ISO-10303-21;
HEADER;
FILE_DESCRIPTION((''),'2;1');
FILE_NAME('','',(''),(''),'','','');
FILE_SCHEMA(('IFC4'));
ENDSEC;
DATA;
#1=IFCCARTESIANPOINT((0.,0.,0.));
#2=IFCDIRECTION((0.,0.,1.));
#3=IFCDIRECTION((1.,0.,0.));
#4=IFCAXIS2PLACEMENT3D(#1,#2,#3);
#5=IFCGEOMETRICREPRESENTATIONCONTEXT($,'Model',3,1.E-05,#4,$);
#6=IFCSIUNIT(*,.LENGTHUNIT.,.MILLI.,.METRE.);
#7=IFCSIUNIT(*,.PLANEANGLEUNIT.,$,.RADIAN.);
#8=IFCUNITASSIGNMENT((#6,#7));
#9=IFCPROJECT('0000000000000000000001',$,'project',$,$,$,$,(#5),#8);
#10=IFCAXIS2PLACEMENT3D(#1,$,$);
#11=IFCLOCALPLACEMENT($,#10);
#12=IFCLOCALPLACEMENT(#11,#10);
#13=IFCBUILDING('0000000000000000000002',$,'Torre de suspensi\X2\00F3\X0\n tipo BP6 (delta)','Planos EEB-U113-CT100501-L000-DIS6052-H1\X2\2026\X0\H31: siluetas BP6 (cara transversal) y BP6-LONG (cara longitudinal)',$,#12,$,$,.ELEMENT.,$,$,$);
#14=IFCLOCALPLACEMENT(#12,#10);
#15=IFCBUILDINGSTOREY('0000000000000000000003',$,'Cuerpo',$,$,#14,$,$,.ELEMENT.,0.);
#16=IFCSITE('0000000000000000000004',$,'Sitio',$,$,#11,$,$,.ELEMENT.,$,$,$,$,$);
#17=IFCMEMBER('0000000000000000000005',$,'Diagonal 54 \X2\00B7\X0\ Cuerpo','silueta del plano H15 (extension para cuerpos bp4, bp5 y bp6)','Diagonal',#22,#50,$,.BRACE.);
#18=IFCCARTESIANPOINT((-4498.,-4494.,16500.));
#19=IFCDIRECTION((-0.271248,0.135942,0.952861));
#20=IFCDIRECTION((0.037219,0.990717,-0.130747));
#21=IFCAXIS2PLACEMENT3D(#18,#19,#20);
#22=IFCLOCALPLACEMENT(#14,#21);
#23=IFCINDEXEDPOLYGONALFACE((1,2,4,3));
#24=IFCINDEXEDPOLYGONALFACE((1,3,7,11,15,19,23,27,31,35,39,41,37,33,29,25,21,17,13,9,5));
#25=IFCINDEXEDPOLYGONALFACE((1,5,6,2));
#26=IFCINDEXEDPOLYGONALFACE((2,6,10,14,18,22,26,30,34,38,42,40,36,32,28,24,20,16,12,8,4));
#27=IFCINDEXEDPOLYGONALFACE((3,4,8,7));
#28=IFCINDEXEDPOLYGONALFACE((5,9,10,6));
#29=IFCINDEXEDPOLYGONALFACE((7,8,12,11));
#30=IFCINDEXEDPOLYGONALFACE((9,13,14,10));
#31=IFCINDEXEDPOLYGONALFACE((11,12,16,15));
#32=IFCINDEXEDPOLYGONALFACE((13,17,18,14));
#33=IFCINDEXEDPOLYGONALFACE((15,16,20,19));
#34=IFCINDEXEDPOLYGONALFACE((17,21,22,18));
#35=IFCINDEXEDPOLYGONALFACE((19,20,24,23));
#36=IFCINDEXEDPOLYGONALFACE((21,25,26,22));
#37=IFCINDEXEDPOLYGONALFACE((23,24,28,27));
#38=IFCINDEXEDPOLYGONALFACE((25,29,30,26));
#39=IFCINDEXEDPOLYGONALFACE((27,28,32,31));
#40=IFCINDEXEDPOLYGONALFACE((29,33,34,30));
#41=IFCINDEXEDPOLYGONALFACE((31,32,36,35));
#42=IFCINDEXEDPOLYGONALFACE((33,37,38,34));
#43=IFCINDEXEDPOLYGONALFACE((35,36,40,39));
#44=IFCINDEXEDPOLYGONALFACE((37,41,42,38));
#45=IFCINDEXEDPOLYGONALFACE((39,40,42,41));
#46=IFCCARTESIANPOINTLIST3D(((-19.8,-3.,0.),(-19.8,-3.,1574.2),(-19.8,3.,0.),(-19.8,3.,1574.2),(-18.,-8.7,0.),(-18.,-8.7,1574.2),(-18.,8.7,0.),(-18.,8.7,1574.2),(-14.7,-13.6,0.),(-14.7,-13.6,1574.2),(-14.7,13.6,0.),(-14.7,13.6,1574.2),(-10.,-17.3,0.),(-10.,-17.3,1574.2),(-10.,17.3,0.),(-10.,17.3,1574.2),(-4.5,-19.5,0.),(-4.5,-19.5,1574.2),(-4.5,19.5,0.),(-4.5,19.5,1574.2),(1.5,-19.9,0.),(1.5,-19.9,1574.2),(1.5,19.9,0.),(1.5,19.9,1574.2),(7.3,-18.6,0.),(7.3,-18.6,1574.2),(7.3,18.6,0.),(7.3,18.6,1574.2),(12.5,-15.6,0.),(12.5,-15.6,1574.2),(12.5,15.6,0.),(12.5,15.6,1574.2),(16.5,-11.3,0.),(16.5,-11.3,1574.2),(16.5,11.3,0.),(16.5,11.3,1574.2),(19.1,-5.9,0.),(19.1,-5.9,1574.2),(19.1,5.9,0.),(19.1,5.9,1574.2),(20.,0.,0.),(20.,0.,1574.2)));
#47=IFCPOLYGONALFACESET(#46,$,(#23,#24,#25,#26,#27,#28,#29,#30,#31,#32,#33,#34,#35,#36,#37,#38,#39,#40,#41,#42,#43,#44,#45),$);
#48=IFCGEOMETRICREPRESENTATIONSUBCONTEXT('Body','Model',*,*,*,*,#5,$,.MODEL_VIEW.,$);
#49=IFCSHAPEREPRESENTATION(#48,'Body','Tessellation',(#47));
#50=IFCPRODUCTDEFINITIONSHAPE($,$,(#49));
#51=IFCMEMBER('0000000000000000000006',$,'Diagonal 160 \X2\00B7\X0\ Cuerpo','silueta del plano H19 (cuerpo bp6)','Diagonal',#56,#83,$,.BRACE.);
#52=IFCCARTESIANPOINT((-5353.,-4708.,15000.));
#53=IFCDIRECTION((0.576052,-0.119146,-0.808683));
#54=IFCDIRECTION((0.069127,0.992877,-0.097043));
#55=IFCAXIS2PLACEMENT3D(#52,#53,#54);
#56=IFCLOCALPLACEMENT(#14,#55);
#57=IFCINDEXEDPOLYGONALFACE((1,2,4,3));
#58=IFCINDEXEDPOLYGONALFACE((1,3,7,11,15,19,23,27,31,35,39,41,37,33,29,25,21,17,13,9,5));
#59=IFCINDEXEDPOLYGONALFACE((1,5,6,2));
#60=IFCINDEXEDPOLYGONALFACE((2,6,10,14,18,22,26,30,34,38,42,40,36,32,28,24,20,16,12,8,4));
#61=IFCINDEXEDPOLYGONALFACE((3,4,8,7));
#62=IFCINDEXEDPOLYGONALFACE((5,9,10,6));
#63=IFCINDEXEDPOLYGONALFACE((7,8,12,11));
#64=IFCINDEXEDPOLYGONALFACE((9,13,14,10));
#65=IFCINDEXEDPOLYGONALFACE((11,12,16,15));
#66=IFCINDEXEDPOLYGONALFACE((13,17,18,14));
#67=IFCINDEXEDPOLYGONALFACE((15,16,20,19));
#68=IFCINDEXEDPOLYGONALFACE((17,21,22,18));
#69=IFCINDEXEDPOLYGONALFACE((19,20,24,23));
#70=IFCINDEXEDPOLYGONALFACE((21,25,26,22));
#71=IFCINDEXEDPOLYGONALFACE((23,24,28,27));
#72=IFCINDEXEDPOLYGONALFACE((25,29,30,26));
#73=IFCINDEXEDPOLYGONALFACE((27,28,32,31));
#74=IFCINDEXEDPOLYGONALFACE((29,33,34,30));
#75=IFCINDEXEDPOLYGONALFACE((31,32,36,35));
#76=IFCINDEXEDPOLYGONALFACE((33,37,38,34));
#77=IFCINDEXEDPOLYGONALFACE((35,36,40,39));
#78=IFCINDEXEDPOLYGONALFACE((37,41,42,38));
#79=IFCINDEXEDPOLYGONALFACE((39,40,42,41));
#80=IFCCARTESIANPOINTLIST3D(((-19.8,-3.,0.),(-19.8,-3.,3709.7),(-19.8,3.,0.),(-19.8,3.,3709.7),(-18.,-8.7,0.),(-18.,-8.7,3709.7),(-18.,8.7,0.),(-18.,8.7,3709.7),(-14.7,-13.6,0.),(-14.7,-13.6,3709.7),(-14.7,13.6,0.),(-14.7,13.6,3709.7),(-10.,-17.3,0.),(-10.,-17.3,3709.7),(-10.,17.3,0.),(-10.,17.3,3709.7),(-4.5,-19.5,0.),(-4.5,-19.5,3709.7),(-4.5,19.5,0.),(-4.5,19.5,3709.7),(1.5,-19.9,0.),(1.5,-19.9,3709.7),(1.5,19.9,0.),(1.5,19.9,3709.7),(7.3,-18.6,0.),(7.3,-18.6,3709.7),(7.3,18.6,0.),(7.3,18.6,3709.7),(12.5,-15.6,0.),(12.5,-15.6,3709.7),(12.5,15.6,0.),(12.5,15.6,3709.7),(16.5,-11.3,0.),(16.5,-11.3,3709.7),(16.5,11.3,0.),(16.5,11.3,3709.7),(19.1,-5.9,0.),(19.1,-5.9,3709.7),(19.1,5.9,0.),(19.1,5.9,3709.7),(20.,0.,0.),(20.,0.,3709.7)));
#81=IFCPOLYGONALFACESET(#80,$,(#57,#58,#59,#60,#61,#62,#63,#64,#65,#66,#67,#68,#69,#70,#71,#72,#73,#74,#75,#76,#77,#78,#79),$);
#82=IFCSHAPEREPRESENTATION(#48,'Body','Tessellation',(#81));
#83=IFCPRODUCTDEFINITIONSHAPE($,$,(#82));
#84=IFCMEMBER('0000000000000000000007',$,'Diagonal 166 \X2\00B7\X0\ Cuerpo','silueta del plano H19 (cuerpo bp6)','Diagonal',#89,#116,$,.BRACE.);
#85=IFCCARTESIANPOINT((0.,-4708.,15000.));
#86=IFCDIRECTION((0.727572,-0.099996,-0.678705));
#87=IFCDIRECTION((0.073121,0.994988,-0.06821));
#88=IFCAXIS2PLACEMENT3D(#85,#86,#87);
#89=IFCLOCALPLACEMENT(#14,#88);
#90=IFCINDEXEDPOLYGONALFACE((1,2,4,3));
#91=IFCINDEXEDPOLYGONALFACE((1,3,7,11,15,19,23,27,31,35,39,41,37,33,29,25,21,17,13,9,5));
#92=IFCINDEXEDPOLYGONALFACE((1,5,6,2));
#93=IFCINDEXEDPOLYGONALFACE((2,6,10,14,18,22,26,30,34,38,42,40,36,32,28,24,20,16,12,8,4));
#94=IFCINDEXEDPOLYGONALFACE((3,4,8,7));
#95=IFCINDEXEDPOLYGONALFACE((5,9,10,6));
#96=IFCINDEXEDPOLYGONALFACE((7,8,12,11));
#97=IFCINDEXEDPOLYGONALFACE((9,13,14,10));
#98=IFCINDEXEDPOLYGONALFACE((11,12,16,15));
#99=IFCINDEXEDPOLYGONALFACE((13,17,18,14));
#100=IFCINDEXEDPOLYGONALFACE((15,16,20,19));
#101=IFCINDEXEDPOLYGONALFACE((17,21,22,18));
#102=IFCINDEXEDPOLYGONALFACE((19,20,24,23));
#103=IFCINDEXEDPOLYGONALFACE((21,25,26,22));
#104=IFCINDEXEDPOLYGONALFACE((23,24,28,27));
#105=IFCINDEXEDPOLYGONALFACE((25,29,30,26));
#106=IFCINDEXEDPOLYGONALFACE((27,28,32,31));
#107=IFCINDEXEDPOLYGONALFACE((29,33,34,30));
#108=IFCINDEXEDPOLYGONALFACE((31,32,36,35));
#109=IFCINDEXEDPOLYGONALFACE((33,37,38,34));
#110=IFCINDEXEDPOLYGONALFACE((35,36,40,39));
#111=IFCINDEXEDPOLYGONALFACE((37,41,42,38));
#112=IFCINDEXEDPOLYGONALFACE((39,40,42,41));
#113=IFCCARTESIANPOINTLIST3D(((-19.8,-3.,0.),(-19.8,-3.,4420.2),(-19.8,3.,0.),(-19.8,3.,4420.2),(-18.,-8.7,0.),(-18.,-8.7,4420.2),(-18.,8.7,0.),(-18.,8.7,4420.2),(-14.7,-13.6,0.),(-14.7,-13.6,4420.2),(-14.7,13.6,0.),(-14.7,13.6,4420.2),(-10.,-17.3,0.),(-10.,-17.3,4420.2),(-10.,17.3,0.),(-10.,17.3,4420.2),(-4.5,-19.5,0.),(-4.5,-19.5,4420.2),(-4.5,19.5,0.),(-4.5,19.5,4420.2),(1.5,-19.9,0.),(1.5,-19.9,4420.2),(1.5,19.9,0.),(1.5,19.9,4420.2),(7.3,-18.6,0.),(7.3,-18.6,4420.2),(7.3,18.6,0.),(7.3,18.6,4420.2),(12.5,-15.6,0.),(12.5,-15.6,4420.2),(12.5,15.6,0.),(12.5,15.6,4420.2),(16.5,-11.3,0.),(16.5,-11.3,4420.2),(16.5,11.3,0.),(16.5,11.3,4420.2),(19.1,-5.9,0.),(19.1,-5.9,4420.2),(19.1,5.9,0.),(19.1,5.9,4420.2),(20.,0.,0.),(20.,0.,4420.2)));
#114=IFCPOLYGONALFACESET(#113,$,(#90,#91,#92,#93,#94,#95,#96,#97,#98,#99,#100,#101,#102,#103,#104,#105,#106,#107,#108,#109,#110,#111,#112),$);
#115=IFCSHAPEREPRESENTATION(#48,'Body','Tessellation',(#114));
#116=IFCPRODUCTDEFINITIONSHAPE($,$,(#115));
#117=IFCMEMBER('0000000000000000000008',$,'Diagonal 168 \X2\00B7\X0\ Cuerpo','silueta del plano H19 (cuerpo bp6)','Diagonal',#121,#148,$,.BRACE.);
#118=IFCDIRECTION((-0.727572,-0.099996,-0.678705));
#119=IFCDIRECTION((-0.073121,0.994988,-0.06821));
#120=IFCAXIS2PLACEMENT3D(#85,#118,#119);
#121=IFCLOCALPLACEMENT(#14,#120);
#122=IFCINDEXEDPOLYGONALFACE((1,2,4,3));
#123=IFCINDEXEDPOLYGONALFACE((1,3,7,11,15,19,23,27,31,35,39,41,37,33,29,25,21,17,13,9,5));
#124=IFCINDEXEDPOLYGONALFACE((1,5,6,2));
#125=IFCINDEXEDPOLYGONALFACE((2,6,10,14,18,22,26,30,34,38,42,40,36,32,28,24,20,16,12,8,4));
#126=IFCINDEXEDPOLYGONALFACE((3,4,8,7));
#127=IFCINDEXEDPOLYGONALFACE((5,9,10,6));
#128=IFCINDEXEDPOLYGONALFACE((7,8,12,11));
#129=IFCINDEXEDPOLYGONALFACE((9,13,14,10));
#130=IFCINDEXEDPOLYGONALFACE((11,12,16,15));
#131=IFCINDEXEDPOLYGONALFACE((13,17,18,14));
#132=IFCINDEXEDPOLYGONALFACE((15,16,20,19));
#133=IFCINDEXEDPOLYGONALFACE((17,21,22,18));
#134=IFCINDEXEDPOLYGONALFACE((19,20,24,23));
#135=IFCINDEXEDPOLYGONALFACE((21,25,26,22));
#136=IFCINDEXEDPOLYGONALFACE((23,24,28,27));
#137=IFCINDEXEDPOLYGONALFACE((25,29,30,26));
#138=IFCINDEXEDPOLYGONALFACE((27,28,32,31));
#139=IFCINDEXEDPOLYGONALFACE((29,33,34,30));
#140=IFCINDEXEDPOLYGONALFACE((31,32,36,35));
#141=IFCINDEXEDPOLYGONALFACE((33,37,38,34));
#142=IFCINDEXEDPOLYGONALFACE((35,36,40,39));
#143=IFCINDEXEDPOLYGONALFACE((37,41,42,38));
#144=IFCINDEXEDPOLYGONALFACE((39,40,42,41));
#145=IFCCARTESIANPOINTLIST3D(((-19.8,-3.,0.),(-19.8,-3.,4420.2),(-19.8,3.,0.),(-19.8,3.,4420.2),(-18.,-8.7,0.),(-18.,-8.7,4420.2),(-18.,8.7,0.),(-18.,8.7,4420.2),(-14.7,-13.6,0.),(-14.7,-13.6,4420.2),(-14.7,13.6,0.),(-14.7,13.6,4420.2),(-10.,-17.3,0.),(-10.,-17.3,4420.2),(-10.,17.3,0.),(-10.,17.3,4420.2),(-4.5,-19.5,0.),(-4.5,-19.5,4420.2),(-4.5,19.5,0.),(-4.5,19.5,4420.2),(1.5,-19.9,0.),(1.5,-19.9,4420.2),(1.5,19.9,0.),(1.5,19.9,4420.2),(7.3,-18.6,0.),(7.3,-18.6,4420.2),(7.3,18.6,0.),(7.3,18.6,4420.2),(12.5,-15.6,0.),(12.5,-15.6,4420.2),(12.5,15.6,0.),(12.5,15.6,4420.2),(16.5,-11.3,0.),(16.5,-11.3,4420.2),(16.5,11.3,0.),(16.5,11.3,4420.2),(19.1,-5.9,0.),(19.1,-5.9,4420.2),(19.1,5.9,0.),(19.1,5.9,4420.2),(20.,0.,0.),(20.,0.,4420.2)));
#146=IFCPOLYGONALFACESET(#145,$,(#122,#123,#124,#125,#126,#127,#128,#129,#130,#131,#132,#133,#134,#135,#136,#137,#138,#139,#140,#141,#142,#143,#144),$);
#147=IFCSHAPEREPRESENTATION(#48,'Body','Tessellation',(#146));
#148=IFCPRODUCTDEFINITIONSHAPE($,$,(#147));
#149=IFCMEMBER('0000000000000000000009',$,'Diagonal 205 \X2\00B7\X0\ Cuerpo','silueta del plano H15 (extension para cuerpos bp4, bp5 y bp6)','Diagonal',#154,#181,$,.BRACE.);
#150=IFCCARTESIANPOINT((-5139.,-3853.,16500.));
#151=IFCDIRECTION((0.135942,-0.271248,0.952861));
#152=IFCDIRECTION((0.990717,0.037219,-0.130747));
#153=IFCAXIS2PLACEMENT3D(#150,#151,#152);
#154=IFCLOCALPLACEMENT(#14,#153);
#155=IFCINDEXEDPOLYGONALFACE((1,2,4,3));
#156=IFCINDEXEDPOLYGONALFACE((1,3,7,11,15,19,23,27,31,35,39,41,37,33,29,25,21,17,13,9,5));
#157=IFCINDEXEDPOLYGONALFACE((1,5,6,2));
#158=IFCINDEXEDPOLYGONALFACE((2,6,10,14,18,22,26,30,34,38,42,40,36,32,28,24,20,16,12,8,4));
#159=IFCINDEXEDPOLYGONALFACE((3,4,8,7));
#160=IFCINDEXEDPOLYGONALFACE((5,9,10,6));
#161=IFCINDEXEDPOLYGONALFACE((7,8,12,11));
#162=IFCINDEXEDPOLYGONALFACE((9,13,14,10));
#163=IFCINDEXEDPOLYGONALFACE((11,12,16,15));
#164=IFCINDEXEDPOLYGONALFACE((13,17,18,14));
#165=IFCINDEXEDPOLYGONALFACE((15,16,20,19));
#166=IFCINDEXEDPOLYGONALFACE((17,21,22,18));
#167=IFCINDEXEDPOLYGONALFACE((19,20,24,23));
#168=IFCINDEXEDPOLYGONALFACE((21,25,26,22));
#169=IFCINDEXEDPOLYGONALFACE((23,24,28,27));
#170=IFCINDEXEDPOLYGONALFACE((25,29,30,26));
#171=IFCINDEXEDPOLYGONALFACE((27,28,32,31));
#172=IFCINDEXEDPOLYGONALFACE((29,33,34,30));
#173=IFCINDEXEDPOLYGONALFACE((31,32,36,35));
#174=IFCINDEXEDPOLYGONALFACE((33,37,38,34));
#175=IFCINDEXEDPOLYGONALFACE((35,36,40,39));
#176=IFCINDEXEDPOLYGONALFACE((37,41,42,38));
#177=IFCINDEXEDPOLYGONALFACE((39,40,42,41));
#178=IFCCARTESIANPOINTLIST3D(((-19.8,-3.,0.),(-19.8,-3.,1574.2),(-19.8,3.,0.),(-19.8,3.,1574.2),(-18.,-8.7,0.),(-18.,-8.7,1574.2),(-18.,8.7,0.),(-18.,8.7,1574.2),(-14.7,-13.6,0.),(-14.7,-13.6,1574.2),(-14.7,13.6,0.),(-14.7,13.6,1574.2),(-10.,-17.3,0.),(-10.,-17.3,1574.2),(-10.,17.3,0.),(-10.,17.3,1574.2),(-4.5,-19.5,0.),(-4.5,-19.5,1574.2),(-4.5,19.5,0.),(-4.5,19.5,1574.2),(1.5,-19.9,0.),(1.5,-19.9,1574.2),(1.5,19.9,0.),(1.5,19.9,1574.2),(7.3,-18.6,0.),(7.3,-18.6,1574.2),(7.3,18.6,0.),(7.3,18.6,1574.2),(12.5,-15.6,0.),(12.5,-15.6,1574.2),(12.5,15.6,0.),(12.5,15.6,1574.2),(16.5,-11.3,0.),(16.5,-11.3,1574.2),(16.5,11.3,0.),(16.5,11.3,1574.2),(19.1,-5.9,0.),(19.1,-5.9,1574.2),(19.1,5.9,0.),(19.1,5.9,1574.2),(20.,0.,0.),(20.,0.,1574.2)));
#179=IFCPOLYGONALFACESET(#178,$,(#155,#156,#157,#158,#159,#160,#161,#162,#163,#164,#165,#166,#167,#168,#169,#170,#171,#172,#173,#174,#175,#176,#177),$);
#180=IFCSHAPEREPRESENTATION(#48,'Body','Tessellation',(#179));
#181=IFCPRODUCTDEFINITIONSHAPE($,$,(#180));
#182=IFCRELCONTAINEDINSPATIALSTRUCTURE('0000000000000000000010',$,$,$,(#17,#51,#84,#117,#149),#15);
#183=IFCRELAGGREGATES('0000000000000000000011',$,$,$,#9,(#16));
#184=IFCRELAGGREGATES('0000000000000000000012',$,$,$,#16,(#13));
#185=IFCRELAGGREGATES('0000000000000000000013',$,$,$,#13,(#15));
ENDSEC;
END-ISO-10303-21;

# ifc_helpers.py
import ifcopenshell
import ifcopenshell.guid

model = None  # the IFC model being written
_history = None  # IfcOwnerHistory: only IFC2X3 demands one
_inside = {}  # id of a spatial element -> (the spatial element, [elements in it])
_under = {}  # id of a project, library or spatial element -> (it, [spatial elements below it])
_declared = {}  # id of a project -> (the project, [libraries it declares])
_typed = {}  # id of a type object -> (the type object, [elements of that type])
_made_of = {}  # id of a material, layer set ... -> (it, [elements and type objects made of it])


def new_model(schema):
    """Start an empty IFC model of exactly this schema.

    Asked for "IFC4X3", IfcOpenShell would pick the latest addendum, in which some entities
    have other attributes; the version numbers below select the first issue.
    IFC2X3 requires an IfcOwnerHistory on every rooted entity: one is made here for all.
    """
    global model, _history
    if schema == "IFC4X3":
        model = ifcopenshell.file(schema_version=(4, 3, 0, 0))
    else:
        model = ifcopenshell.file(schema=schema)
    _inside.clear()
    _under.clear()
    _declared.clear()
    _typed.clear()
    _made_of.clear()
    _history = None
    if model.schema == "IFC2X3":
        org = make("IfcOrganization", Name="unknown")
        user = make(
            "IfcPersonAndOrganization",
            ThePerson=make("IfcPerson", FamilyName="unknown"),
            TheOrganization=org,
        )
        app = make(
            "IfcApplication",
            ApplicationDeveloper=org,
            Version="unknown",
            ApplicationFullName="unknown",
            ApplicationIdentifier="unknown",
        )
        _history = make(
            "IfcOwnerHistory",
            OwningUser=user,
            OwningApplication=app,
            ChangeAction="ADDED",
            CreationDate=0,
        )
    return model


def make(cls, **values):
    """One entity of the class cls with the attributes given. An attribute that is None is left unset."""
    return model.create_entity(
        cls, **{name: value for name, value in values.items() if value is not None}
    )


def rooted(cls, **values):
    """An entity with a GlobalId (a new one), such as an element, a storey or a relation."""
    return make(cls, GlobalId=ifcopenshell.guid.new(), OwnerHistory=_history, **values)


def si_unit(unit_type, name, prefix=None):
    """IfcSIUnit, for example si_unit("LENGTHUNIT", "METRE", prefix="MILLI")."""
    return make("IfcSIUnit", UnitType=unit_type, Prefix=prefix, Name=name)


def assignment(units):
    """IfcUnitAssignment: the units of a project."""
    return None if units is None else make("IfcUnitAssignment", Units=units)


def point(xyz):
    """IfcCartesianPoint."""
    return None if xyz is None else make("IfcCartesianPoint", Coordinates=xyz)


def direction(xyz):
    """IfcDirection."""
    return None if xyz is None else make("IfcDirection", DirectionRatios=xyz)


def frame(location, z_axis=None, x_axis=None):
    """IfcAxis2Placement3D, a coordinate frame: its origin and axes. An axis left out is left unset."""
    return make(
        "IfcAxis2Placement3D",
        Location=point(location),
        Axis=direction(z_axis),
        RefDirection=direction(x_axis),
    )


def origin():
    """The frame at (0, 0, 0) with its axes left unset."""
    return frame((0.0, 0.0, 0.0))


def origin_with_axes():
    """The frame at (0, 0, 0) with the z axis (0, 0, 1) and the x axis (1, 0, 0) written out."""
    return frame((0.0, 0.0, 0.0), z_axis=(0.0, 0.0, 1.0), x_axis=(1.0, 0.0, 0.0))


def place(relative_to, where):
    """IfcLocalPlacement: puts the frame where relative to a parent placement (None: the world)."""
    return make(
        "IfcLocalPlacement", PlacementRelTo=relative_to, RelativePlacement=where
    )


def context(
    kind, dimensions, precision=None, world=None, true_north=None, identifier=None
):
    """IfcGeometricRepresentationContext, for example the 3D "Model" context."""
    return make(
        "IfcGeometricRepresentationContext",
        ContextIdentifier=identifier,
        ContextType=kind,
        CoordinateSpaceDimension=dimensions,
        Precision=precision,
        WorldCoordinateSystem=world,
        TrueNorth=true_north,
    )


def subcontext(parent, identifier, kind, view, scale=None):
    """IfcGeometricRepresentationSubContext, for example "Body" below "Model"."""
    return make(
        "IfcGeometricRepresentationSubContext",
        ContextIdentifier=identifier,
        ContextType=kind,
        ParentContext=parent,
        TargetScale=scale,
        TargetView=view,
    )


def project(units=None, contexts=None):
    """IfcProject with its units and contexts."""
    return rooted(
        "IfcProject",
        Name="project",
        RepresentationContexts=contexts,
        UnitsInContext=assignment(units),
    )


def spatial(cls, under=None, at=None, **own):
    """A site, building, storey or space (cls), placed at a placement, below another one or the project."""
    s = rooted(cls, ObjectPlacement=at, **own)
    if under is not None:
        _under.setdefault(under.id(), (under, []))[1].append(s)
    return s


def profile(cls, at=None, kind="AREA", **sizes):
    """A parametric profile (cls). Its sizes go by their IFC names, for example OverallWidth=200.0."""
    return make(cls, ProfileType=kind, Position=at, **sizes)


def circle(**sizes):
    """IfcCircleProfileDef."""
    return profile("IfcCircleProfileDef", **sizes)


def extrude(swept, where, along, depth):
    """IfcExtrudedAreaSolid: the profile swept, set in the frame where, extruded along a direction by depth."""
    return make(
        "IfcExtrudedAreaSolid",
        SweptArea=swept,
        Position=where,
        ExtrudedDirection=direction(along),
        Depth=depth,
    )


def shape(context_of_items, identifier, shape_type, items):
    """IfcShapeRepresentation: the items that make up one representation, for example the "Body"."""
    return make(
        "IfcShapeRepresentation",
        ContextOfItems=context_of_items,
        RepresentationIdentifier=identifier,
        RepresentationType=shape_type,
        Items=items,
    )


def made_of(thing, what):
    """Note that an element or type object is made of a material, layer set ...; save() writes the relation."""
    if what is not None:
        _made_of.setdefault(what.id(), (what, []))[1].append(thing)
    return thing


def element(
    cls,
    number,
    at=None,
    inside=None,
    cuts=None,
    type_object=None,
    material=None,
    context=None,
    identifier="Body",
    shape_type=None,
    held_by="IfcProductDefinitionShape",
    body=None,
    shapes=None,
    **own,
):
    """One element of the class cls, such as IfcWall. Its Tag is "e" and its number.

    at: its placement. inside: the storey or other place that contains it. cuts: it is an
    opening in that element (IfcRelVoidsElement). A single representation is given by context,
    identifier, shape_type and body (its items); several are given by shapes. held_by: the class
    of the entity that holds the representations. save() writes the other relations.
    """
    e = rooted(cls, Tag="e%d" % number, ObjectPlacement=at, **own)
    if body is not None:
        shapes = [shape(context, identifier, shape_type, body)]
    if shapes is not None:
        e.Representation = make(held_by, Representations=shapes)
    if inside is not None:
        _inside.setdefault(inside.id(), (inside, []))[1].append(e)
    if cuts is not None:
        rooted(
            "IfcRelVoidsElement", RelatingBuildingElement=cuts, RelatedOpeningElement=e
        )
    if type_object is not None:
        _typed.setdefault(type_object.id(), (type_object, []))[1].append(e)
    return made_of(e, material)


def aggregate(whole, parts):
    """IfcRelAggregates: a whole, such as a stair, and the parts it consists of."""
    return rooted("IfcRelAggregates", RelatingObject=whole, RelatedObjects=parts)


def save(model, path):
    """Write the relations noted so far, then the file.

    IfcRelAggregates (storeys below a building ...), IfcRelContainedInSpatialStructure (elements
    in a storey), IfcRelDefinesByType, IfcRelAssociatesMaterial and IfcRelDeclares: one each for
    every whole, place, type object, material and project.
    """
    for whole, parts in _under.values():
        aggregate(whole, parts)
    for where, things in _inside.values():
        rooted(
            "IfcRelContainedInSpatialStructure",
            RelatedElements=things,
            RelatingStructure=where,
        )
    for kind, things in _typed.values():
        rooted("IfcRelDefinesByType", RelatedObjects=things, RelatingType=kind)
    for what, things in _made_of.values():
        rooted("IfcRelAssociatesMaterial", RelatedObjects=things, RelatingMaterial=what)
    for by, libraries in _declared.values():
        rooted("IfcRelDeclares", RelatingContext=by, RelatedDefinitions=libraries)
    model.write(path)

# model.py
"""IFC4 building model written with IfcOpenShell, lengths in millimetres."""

from ifc_helpers import new_model, si_unit, frame, origin, origin_with_axes, place, context, subcontext, project, spatial, circle, extrude, element, save


model = new_model("IFC4")

# Units and contexts
model_context = context("Model", 3, precision=1e-05, world=origin_with_axes())
body_context = subcontext(model_context, "Body", "Model", "MODEL_VIEW")
ifc_project = project(units=[si_unit("LENGTHUNIT", "METRE", prefix="MILLI"), si_unit("PLANEANGLEUNIT", "RADIAN")], contexts=[model_context])

# Site, building, storey
site_placement = place(None, origin())
site = spatial("IfcSite", under=ifc_project, at=site_placement, Name="Sitio", CompositionType="ELEMENT")
building_placement = place(site_placement, origin())
building = spatial("IfcBuilding", under=site, at=building_placement, Name="Torre de suspensión tipo BP6 (delta)", Description="Planos EEB-U113-CT100501-L000-DIS6052-H1…H31: siluetas BP6 (cara transversal) y BP6-LONG (cara longitudinal)", CompositionType="ELEMENT")
storey_placement = place(building_placement, origin())
storey = spatial("IfcBuildingStorey", under=building, at=storey_placement, Name="Cuerpo", CompositionType="ELEMENT", Elevation=0.0)

# Members
member_1_placement = place(storey_placement, frame((-4498.0, -4494.0, 16500.0), z_axis=(-0.271248, 0.135942, 0.952861), x_axis=(0.037219, 0.990717, -0.130747)))
element("IfcMember", 1, at=member_1_placement, inside=storey, Name="Diagonal 54 · Cuerpo", Description="silueta del plano H15 (extension para cuerpos bp4, bp5 y bp6)", ObjectType="Diagonal", PredefinedType="BRACE", context=body_context, shape_type="SweptSolid", body=[
    extrude(circle(Radius=20.0), None, (0.0, 0.0, 1.0), 1574.2),
])
member_2_placement = place(storey_placement, frame((-5353.0, -4708.0, 15000.0), z_axis=(0.576052, -0.119146, -0.808683), x_axis=(0.069127, 0.992877, -0.097043)))
element("IfcMember", 2, at=member_2_placement, inside=storey, Name="Diagonal 160 · Cuerpo", Description="silueta del plano H19 (cuerpo bp6)", ObjectType="Diagonal", PredefinedType="BRACE", context=body_context, shape_type="SweptSolid", body=[
    extrude(circle(Radius=20.0), None, (0.0, 0.0, 1.0), 3709.7),
])
for number, where, z_axis, x_axis, name in (
    (3, (0.0, -4708.0, 15000.0), (0.727572, -0.099996, -0.678705), (0.073121, 0.994988, -0.06821), "Diagonal 166 · Cuerpo"),
    (4, (0.0, -4708.0, 15000.0), (-0.727572, -0.099996, -0.678705), (-0.073121, 0.994988, -0.06821), "Diagonal 168 · Cuerpo"),
):
    element("IfcMember", number, at=place(storey_placement, frame(where, z_axis=z_axis, x_axis=x_axis)), inside=storey, Name=name, Description="silueta del plano H19 (cuerpo bp6)", ObjectType="Diagonal", PredefinedType="BRACE", context=body_context, shape_type="SweptSolid", body=[
        extrude(circle(Radius=20.0), None, (0.0, 0.0, 1.0), 4420.2),
    ])
member_3_placement = place(storey_placement, frame((-5139.0, -3853.0, 16500.0), z_axis=(0.135942, -0.271248, 0.952861), x_axis=(0.990717, 0.037219, -0.130747)))
element("IfcMember", 5, at=member_3_placement, inside=storey, Name="Diagonal 205 · Cuerpo", Description="silueta del plano H15 (extension para cuerpos bp4, bp5 y bp6)", ObjectType="Diagonal", PredefinedType="BRACE", context=body_context, shape_type="SweptSolid", body=[
    extrude(circle(Radius=20.0), None, (0.0, 0.0, 1.0), 1574.2),
])

save(model, "model.ifc")
